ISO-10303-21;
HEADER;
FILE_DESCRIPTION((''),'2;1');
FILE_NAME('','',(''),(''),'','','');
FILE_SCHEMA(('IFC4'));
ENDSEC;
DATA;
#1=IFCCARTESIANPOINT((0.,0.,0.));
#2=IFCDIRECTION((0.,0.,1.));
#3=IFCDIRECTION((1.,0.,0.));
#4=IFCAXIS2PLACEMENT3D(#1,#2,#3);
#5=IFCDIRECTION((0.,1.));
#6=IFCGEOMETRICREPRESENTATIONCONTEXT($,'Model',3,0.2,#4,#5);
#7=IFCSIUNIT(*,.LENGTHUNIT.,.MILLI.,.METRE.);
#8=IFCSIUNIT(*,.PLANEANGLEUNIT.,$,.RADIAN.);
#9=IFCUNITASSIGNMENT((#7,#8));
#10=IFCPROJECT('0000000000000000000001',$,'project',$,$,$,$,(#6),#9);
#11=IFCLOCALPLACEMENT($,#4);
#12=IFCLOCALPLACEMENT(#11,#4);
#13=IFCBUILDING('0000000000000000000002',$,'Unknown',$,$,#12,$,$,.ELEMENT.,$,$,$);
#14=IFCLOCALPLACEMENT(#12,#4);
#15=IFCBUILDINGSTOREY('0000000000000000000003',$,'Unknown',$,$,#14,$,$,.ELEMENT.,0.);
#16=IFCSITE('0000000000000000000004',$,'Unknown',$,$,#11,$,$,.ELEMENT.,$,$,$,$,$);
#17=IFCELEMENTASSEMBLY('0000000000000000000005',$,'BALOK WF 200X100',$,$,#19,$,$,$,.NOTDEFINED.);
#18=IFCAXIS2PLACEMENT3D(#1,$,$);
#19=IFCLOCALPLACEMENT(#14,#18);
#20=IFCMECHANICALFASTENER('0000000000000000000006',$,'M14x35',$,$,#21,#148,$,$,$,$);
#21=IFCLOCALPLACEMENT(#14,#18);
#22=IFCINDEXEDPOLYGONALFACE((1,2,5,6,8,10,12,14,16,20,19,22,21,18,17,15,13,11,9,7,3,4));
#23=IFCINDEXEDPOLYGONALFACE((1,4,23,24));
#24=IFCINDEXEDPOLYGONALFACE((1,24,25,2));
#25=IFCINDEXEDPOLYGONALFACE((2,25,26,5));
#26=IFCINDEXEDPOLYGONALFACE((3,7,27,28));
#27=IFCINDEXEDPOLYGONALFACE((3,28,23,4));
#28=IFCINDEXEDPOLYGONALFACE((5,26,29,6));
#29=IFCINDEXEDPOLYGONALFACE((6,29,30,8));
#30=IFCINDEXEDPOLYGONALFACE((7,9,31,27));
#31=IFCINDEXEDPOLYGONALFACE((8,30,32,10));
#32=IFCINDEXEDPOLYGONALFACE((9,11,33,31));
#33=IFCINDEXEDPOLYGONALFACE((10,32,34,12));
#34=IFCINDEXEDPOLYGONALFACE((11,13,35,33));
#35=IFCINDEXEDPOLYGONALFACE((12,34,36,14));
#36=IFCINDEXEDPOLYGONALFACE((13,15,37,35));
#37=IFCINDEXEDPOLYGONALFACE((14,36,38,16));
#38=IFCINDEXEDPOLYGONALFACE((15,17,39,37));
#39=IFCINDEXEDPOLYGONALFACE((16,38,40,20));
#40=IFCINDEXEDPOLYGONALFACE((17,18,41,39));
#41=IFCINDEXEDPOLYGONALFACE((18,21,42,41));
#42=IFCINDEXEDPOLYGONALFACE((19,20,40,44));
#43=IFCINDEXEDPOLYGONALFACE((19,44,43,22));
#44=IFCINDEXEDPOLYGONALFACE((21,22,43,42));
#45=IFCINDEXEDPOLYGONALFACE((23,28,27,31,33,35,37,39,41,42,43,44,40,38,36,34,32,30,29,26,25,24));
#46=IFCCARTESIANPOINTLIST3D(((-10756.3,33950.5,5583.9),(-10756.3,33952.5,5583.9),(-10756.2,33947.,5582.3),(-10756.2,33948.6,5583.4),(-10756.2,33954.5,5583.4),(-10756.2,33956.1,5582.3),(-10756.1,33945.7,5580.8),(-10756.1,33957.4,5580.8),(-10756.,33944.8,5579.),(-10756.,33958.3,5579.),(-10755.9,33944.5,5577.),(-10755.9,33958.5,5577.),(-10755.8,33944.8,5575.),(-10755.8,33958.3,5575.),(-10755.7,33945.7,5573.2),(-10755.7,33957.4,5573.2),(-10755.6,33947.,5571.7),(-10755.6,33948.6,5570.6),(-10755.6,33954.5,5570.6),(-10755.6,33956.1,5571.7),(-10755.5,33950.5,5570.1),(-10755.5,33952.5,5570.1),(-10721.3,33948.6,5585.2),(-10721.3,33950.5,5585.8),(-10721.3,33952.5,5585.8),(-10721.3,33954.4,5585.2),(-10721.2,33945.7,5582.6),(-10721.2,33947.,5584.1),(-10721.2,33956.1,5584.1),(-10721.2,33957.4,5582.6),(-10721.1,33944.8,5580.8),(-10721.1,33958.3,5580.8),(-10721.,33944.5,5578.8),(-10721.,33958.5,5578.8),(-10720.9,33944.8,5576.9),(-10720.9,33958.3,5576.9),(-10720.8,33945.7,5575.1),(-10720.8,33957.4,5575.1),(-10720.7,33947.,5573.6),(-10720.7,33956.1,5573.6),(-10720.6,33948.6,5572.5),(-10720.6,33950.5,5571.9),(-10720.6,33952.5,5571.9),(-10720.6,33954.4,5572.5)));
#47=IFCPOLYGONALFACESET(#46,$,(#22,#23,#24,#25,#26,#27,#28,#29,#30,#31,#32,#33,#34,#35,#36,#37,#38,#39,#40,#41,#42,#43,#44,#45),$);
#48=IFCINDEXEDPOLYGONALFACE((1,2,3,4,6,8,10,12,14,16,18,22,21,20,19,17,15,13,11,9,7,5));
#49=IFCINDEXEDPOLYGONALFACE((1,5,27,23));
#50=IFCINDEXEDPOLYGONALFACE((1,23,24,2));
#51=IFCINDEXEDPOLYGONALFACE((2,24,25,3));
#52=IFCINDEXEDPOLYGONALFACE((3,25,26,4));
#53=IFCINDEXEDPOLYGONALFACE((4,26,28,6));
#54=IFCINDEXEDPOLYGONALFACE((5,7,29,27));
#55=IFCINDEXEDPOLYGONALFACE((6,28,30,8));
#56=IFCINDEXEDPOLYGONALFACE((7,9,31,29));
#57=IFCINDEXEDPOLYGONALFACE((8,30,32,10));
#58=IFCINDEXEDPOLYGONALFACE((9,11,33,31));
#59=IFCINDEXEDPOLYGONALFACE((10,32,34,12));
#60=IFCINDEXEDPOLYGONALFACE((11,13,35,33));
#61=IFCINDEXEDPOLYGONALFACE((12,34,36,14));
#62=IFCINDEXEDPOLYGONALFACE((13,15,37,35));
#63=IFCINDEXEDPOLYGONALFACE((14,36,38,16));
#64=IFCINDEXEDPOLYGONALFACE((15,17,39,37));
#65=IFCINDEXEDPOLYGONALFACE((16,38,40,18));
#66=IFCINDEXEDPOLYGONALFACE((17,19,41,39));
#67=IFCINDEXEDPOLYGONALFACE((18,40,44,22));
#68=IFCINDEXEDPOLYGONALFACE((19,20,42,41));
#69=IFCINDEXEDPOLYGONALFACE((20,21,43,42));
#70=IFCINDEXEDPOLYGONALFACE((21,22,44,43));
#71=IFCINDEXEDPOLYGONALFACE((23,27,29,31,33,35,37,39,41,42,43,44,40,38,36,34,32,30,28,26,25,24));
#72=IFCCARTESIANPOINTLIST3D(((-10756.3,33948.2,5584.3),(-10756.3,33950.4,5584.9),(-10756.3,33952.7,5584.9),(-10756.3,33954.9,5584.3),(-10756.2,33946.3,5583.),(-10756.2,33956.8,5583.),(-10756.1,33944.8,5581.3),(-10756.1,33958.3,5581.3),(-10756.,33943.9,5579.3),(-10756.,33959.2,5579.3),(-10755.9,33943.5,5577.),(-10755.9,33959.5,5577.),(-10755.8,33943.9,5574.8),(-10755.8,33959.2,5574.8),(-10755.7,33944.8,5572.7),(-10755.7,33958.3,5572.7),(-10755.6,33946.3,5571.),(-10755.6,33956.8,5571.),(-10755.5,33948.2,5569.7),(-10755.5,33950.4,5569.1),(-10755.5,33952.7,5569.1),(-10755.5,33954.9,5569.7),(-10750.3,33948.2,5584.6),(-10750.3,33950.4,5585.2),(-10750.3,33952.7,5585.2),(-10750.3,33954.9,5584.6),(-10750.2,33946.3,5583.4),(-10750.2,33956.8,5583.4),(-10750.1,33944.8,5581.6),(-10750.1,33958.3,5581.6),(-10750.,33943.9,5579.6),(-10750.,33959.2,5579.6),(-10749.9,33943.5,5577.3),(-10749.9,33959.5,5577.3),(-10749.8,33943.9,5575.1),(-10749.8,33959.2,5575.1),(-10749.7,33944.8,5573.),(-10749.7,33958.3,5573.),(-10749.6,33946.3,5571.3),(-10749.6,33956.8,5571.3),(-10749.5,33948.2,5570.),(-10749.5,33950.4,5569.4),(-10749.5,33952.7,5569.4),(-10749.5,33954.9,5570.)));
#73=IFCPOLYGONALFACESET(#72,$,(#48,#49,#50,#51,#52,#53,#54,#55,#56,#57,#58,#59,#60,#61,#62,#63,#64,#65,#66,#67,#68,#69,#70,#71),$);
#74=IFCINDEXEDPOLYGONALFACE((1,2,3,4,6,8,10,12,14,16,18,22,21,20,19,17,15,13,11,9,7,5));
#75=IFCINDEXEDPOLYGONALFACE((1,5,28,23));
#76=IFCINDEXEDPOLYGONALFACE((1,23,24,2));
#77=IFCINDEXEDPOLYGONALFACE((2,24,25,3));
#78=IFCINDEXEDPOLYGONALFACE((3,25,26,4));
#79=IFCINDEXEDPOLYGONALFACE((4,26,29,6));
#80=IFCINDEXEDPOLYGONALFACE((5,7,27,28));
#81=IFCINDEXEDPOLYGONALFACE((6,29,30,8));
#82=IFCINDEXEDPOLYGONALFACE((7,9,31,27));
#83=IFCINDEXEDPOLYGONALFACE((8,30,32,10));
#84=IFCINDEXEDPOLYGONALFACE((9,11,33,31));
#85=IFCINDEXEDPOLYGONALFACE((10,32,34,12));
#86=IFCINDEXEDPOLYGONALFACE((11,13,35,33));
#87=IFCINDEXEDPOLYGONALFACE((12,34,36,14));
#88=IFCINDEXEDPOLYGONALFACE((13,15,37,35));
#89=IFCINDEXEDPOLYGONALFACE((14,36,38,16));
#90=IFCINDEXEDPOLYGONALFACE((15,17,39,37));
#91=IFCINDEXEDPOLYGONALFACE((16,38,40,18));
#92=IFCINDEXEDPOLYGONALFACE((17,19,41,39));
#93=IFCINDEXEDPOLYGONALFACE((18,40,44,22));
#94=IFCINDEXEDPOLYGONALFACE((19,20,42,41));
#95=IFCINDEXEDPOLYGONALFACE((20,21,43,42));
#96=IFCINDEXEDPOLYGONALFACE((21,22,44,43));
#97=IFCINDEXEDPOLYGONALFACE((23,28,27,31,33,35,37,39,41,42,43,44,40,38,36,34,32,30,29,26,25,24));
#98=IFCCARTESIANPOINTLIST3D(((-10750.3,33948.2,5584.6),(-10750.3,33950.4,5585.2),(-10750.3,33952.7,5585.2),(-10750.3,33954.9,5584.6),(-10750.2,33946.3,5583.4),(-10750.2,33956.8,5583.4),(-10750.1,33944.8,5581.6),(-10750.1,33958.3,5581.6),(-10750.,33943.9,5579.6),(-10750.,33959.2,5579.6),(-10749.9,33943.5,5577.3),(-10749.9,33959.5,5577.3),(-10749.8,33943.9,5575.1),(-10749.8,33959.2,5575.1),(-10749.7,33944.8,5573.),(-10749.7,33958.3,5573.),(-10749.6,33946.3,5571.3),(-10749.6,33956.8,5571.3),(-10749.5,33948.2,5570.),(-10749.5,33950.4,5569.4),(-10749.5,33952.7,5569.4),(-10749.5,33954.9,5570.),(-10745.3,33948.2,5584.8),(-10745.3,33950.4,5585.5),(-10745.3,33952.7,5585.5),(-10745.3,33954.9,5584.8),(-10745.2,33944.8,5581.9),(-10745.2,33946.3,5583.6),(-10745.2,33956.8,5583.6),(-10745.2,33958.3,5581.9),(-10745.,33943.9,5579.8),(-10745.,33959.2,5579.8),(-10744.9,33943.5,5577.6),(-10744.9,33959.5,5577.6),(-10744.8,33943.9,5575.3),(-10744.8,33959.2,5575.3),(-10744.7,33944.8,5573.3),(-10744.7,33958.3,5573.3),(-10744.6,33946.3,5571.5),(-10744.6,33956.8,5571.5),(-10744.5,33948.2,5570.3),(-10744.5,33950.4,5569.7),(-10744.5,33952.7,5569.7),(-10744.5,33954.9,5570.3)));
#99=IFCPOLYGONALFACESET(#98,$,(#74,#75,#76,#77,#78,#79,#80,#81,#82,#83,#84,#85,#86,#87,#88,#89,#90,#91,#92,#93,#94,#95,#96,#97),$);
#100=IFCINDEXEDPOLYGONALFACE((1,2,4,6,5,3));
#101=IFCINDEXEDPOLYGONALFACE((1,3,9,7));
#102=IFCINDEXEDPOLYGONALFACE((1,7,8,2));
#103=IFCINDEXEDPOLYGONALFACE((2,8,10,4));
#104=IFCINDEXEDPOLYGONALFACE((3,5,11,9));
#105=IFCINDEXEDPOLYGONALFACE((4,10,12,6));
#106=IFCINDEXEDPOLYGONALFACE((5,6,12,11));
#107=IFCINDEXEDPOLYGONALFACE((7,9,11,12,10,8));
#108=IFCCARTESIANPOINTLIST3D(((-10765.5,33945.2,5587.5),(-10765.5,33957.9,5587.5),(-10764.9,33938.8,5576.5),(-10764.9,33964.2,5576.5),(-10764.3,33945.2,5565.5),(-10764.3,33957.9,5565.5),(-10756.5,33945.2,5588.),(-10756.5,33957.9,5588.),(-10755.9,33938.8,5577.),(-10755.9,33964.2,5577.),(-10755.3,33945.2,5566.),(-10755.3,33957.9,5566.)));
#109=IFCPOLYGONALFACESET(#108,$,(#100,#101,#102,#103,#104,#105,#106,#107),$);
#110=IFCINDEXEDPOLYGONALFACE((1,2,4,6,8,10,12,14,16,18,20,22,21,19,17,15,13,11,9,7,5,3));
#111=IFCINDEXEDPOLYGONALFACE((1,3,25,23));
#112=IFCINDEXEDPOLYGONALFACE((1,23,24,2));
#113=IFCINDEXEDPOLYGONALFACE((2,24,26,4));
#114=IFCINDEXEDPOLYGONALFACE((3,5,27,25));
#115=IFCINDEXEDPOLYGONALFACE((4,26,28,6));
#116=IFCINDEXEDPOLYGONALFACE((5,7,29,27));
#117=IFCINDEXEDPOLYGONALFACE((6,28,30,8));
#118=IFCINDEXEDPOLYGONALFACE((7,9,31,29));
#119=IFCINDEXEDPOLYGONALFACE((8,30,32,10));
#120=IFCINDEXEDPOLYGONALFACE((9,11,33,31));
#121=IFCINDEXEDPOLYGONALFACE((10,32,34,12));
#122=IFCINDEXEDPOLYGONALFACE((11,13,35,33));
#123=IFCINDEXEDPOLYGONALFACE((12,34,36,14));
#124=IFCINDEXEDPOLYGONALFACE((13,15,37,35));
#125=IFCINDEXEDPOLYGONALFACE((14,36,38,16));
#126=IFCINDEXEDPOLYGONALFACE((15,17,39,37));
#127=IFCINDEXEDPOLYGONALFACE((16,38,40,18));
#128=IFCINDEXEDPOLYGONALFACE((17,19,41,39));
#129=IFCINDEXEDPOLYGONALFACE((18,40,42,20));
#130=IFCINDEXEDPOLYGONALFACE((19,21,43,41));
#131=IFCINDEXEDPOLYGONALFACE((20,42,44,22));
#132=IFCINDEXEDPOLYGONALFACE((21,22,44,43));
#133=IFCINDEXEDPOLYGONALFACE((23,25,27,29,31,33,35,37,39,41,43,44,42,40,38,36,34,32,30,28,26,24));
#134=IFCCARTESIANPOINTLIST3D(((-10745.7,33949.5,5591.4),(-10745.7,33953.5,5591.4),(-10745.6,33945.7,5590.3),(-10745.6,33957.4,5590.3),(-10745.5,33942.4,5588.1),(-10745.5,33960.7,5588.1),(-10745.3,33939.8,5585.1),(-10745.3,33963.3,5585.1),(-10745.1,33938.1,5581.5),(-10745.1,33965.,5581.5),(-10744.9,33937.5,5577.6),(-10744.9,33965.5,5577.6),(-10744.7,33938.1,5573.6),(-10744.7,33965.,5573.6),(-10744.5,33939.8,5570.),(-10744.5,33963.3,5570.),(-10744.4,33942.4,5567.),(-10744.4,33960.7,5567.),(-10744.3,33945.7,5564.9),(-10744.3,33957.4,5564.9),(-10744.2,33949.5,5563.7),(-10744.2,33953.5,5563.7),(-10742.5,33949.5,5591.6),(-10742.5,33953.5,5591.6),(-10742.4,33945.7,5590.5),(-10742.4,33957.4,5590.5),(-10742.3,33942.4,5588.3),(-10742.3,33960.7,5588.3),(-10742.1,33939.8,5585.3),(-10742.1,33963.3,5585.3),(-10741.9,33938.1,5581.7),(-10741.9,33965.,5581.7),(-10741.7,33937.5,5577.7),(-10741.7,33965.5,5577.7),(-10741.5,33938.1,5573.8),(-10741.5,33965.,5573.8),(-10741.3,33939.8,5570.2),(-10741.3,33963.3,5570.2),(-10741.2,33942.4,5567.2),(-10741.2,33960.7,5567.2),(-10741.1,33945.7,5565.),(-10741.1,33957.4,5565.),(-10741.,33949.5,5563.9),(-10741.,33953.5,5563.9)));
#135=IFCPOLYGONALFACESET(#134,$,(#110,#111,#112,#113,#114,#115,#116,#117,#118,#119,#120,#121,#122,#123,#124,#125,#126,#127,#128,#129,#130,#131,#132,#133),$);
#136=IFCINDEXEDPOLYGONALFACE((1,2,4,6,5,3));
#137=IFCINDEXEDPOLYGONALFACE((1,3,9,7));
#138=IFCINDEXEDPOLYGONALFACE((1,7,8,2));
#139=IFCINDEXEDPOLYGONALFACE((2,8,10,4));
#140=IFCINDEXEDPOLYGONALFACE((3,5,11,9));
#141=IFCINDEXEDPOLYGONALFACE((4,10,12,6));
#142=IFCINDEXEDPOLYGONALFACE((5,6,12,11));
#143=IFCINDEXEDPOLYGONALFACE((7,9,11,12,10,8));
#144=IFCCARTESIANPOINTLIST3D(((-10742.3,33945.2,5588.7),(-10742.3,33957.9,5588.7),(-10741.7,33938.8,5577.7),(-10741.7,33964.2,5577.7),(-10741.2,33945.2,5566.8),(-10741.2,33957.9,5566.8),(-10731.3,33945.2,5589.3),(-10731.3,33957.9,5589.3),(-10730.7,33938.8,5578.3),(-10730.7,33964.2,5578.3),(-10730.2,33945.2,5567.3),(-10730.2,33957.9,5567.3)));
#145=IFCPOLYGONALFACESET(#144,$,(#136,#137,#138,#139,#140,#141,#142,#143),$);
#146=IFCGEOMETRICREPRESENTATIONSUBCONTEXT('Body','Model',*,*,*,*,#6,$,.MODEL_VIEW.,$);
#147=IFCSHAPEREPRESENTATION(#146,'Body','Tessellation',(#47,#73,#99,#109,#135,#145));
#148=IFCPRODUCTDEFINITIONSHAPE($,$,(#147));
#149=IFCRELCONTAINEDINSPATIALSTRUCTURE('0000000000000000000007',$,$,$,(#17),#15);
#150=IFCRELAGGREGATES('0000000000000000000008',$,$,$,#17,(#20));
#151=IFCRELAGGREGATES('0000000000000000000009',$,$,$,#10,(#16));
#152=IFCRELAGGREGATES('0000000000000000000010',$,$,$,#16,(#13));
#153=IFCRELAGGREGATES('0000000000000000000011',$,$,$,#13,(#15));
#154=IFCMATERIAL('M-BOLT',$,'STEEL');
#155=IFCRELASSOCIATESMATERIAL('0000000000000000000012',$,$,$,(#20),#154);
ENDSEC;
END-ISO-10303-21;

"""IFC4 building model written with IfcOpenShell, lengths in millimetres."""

from ifc_helpers import new_model, si_unit, direction, frame, origin_with_axes, place, context, subcontext, project, spatial, line, arc, indexed_curve, outline, extrude, source, transform, mapped, material, element, aggregate, save


model = new_model("IFC4")

# Units and contexts
model_context = context("Model", 3, precision=0.2, world=origin_with_axes(), true_north=direction((0.0, 1.0)))
body_context = subcontext(model_context, "Body", "Model", "MODEL_VIEW")
ifc_project = project(units=[si_unit("LENGTHUNIT", "METRE", prefix="MILLI"), si_unit("PLANEANGLEUNIT", "RADIAN")], contexts=[model_context])

# Site, building, storey
site_placement = place(None, origin_with_axes())
site = spatial("IfcSite", under=ifc_project, at=site_placement, Name="Unknown", CompositionType="ELEMENT")
building_placement = place(site_placement, origin_with_axes())
building = spatial("IfcBuilding", under=site, at=building_placement, Name="Unknown", CompositionType="ELEMENT")
storey_placement = place(building_placement, origin_with_axes())
storey = spatial("IfcBuildingStorey", under=building, at=storey_placement, Name="Unknown", CompositionType="ELEMENT", Elevation=0.0)

# Element assembly
assembly_1_placement = place(storey_placement, frame((-7044.1, 33866.5, 5721.5), z_axis=(0.0, 1.0, 0.0), x_axis=(-0.99863, 0.0, -0.052336)))
assembly_1 = element("IfcElementAssembly", 1, at=assembly_1_placement, inside=storey, Name="BALOK WF 200X100", PredefinedType="NOTDEFINED")

# Mechanical fastener
ifc_material_1 = material(Name="M-BOLT", Category="STEEL")
shared_shape_1 = source(origin_with_axes(), body_context, "Body", "SweptSolid", [
    extrude(outline(indexed_curve([(7.0, 0.0), (0.0, 7.0), (-7.0, 0.0), (0.0, -7.0)], segments=[arc(1, 2, 3), arc(3, 4, 1)])), frame((0.0, 0.0, 0.0), z_axis=(0.0, 0.0, -1.0), x_axis=(0.0, 1.0, 0.0)), (0.0, 0.0, 1.0), 35.0),
    extrude(outline(indexed_curve([(8.0, 0.0), (0.0, 8.0), (-8.0, 0.0), (0.0, -8.0)], segments=[arc(1, 2, 3), arc(3, 4, 1)])), frame((0.0, 0.0, 0.0), z_axis=(0.0, 0.0, -1.0), x_axis=(0.0, 1.0, 0.0)), (0.0, 0.0, 1.0), 6.0),
    extrude(outline(indexed_curve([(8.0, 0.0), (0.0, 8.0), (-8.0, 0.0), (0.0, -8.0)], segments=[arc(1, 2, 3), arc(3, 4, 1)])), frame((0.0, 0.0, -6.0), z_axis=(0.0, 0.0, -1.0), x_axis=(0.0, 1.0, 0.0)), (0.0, 0.0, 1.0), 5.0),
    extrude(outline(indexed_curve([(12.7, 0.0), (6.4, 11.0), (-6.4, 11.0), (-12.7, 0.0), (-6.4, -11.0), (6.4, -11.0)], segments=[line(1, 2, 3, 4, 5, 6, 1)])), frame((0.0, 0.0, 9.0), z_axis=(0.0, 0.0, -1.0), x_axis=(0.0, 1.0, 0.0)), (0.0, 0.0, 1.0), 9.0),
    extrude(outline(indexed_curve([(14.0, 0.0), (0.0, 14.0), (-14.0, 0.0), (0.0, -14.0)], segments=[arc(1, 2, 3), arc(3, 4, 1)])), frame((0.0, 0.0, -11.0), z_axis=(0.0, 0.0, -1.0), x_axis=(0.0, 1.0, 0.0)), (0.0, 0.0, 1.0), 3.2),
    extrude(outline(indexed_curve([(12.7, 0.0), (6.4, 11.0), (-6.4, 11.0), (-12.7, 0.0), (-6.4, -11.0), (6.4, -11.0)], segments=[line(1, 2, 3, 4, 5, 6, 1)])), frame((0.0, 0.0, -14.2), z_axis=(0.0, 0.0, -1.0), x_axis=(0.0, 1.0, 0.0)), (0.0, 0.0, 1.0), 11.0),
])
mechanical_fastener_1_placement = place(assembly_1_placement, frame((3714.2, 50.0, 85.0), z_axis=(1.0, 0.0, 0.000006), x_axis=(0.0, -1.0, 0.0)))
mechanical_fastener_1 = element("IfcMechanicalFastener", 2, at=mechanical_fastener_1_placement, material=ifc_material_1, Name="M14x35", context=body_context, shape_type="MappedRepresentation", body=[
    mapped(shared_shape_1, transform((0.0, 0.0, 0.0))),
])
aggregate(assembly_1, [mechanical_fastener_1])

save(model, "model.ifc")
